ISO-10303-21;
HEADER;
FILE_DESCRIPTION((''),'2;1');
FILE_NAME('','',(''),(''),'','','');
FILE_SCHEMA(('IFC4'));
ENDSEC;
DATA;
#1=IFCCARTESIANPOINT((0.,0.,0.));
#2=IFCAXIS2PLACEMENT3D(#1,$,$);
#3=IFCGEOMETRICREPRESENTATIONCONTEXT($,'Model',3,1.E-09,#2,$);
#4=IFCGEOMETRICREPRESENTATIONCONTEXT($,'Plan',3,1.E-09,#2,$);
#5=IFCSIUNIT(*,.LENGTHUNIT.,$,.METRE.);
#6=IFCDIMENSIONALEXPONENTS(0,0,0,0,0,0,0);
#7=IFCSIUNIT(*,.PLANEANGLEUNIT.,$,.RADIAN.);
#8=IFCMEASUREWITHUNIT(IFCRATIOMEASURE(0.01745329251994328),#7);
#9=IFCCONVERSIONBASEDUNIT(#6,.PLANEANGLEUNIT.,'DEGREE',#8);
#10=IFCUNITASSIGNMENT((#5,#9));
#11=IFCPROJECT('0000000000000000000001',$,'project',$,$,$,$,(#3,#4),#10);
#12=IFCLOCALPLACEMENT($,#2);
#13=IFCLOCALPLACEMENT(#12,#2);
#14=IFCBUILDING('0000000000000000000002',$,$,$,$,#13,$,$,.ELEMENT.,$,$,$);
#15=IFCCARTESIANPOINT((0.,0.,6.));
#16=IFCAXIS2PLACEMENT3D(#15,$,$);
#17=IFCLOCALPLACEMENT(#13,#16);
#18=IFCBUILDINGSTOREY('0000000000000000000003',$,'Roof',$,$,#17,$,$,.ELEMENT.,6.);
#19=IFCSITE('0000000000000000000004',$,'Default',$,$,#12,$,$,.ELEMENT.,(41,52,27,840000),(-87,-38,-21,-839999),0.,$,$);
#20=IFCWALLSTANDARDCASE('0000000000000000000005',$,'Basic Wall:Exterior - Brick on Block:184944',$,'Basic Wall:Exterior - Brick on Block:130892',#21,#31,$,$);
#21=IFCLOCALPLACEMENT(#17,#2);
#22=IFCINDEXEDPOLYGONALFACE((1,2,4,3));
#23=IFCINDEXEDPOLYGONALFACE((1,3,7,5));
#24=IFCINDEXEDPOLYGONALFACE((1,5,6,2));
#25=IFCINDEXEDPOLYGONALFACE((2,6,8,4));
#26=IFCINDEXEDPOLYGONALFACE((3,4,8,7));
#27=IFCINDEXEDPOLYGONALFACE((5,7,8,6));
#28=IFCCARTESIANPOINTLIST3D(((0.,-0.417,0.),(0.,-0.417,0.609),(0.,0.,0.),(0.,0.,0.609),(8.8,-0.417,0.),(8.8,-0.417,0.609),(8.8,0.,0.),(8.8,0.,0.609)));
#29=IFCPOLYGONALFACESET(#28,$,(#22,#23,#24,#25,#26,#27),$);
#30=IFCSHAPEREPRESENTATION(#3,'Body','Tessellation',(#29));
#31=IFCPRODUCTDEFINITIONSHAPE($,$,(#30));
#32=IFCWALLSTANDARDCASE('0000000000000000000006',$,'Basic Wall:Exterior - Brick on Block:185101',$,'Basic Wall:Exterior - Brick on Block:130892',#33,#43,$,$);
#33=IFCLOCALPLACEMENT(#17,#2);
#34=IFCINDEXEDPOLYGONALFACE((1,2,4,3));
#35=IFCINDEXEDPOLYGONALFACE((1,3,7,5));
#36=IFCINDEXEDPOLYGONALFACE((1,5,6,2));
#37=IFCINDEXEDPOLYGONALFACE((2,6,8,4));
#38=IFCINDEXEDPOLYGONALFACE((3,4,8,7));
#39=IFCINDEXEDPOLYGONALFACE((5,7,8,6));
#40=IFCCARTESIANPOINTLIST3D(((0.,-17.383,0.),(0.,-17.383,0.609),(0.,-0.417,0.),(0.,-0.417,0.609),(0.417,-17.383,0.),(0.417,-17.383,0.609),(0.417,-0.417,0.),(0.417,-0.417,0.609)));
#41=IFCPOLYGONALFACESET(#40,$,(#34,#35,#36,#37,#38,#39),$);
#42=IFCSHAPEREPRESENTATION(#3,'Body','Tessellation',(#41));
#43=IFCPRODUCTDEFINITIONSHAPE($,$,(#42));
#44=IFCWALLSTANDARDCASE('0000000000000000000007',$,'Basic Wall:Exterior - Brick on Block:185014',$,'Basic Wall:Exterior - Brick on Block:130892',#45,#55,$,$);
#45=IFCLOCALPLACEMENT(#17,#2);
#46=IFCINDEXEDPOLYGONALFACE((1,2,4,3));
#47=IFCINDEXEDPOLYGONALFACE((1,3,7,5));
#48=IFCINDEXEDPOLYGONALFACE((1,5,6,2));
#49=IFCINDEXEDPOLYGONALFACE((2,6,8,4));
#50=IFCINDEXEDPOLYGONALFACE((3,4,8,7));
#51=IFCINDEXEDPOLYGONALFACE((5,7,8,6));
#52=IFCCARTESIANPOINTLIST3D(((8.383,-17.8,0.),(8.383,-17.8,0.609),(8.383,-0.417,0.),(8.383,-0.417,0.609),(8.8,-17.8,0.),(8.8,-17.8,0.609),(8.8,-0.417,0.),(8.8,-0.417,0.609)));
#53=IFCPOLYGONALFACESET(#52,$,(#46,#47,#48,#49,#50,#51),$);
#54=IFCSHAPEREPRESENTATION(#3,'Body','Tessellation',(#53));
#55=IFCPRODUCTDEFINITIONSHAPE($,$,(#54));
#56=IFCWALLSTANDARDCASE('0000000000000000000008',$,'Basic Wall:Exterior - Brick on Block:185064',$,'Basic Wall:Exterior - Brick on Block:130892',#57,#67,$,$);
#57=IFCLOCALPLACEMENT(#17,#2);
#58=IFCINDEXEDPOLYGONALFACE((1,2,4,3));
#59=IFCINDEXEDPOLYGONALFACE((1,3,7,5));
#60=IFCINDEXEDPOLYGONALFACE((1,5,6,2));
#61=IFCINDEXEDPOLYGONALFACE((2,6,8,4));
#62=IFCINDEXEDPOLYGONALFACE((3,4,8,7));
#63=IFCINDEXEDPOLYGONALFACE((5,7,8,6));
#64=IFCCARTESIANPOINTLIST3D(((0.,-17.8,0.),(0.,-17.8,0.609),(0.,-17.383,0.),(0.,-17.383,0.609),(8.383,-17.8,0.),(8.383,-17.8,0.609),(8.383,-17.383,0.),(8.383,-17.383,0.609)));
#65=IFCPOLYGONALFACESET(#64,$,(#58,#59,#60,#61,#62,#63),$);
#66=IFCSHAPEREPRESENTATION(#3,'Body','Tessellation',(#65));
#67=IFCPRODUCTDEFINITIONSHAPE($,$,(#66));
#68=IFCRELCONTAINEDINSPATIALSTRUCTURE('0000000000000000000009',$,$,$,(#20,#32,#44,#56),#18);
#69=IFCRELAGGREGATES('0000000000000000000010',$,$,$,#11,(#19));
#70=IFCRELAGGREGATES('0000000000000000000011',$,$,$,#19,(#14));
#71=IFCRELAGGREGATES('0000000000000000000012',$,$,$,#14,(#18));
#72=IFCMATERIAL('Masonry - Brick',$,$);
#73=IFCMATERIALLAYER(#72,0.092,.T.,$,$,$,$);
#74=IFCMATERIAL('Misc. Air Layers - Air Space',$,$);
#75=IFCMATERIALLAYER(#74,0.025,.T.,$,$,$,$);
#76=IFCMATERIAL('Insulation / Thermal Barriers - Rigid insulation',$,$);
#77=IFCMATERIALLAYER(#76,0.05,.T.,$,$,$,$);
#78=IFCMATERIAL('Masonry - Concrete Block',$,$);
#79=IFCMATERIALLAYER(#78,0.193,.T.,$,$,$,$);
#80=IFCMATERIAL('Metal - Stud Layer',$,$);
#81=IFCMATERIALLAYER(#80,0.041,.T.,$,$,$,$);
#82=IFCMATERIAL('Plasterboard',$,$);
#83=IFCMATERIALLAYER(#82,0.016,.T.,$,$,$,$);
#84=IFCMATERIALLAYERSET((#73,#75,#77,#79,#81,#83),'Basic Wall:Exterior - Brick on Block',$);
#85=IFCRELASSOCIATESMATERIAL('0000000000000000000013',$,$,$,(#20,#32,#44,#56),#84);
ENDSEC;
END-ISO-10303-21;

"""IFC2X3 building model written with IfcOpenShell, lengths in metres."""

from ifc_helpers import new_model, entity, si_unit, converted_unit, frame, frame_2d, origin, place, context, project, spatial, rectangle, extrude, material, layer, layer_set, layer_usage, element, save


model = new_model("IFC2X3")

# Units and contexts
model_context = context("Model", 3, precision=1e-09, world=origin())
plan_context = context("Plan", 3, precision=1e-09, world=origin())
ifc_project = project(units=[si_unit("LENGTHUNIT", "METRE"), converted_unit("PLANEANGLEUNIT", "DEGREE", entity("IfcRatioMeasure", 0.01745329251994328), si_unit("PLANEANGLEUNIT", "RADIAN"), dimensions=[0, 0, 0, 0, 0, 0, 0])], contexts=[model_context, plan_context])

# Site, building, storey
site_placement = place(None, origin())
site = spatial("IfcSite", under=ifc_project, at=site_placement, Name="Default", CompositionType="ELEMENT", RefLatitude=(41, 52, 27, 840000), RefLongitude=(-87, -38, -21, -839999), RefElevation=0.0)
building_placement = place(site_placement, origin())
building = spatial("IfcBuilding", under=site, at=building_placement, CompositionType="ELEMENT")
storey_placement = place(building_placement, frame((0.0, 0.0, 6.0)))
storey = spatial("IfcBuildingStorey", under=building, at=storey_placement, Name="Roof", CompositionType="ELEMENT", Elevation=6.0)

# Walls
ifc_material_1 = material(Name="Masonry - Brick")
ifc_layer_1 = layer(ifc_material_1, 0.092, ventilated=True)
ifc_material_2 = material(Name="Misc. Air Layers - Air Space")
ifc_layer_2 = layer(ifc_material_2, 0.025, ventilated=True)
ifc_material_3 = material(Name="Insulation / Thermal Barriers - Rigid insulation")
ifc_layer_3 = layer(ifc_material_3, 0.05, ventilated=True)
ifc_material_4 = material(Name="Masonry - Concrete Block")
ifc_layer_4 = layer(ifc_material_4, 0.193, ventilated=True)
ifc_material_5 = material(Name="Metal - Stud Layer")
ifc_layer_5 = layer(ifc_material_5, 0.041, ventilated=True)
ifc_material_6 = material(Name="Plasterboard")
ifc_layer_6 = layer(ifc_material_6, 0.016, ventilated=True)
ifc_layer_set = layer_set([ifc_layer_1, ifc_layer_2, ifc_layer_3, ifc_layer_4, ifc_layer_5, ifc_layer_6], Name="Basic Wall:Exterior - Brick on Block")
ifc_layer_usage = layer_usage(ifc_layer_set, "AXIS2", "NEGATIVE", 0.2085)
wall_1_placement = place(storey_placement, frame((0.0, -0.2085, 0.0)))
element("IfcWallStandardCase", 1, at=wall_1_placement, inside=storey, material=ifc_layer_usage, Name="Basic Wall:Exterior - Brick on Block:184944", ObjectType="Basic Wall:Exterior - Brick on Block:130892", context=model_context, shape_type="SweptSolid", body=[
    extrude(rectangle(XDim=8.8, YDim=0.417, at=frame_2d((4.4, 0.0), x_axis=(-1.0, 0.0))), origin(), (0.0, 0.0, 1.0), 0.609),
])
wall_2_placement = place(storey_placement, frame((0.2085, -17.383, 0.0), z_axis=(0.0, 0.0, 1.0), x_axis=(0.0, 1.0, 0.0)))
element("IfcWallStandardCase", 2, at=wall_2_placement, inside=storey, material=ifc_layer_usage, Name="Basic Wall:Exterior - Brick on Block:185101", ObjectType="Basic Wall:Exterior - Brick on Block:130892", context=model_context, shape_type="SweptSolid", body=[
    extrude(rectangle(XDim=16.966, YDim=0.417, at=frame_2d((8.483, 0.0), x_axis=(-1.0, 0.0))), origin(), (0.0, 0.0, 1.0), 0.609),
])
wall_3_placement = place(storey_placement, frame((8.5915, -0.417, 0.0), z_axis=(0.0, 0.0, 1.0), x_axis=(0.0, -1.0, 0.0)))
element("IfcWallStandardCase", 3, at=wall_3_placement, inside=storey, material=ifc_layer_usage, Name="Basic Wall:Exterior - Brick on Block:185014", ObjectType="Basic Wall:Exterior - Brick on Block:130892", context=model_context, shape_type="SweptSolid", body=[
    extrude(rectangle(XDim=17.383, YDim=0.417, at=frame_2d((8.6915, 0.0), x_axis=(-1.0, 0.0))), origin(), (0.0, 0.0, 1.0), 0.609),
])
wall_4_placement = place(storey_placement, frame((8.383, -17.5915, 0.0), z_axis=(0.0, 0.0, 1.0), x_axis=(-1.0, 0.0, 0.0)))
element("IfcWallStandardCase", 4, at=wall_4_placement, inside=storey, material=ifc_layer_usage, Name="Basic Wall:Exterior - Brick on Block:185064", ObjectType="Basic Wall:Exterior - Brick on Block:130892", context=model_context, shape_type="SweptSolid", body=[
    extrude(rectangle(XDim=8.383, YDim=0.417, at=frame_2d((4.1915, 0.0), x_axis=(-1.0, 0.0))), origin(), (0.0, 0.0, 1.0), 0.609),
])

save(model, "model.ifc")
